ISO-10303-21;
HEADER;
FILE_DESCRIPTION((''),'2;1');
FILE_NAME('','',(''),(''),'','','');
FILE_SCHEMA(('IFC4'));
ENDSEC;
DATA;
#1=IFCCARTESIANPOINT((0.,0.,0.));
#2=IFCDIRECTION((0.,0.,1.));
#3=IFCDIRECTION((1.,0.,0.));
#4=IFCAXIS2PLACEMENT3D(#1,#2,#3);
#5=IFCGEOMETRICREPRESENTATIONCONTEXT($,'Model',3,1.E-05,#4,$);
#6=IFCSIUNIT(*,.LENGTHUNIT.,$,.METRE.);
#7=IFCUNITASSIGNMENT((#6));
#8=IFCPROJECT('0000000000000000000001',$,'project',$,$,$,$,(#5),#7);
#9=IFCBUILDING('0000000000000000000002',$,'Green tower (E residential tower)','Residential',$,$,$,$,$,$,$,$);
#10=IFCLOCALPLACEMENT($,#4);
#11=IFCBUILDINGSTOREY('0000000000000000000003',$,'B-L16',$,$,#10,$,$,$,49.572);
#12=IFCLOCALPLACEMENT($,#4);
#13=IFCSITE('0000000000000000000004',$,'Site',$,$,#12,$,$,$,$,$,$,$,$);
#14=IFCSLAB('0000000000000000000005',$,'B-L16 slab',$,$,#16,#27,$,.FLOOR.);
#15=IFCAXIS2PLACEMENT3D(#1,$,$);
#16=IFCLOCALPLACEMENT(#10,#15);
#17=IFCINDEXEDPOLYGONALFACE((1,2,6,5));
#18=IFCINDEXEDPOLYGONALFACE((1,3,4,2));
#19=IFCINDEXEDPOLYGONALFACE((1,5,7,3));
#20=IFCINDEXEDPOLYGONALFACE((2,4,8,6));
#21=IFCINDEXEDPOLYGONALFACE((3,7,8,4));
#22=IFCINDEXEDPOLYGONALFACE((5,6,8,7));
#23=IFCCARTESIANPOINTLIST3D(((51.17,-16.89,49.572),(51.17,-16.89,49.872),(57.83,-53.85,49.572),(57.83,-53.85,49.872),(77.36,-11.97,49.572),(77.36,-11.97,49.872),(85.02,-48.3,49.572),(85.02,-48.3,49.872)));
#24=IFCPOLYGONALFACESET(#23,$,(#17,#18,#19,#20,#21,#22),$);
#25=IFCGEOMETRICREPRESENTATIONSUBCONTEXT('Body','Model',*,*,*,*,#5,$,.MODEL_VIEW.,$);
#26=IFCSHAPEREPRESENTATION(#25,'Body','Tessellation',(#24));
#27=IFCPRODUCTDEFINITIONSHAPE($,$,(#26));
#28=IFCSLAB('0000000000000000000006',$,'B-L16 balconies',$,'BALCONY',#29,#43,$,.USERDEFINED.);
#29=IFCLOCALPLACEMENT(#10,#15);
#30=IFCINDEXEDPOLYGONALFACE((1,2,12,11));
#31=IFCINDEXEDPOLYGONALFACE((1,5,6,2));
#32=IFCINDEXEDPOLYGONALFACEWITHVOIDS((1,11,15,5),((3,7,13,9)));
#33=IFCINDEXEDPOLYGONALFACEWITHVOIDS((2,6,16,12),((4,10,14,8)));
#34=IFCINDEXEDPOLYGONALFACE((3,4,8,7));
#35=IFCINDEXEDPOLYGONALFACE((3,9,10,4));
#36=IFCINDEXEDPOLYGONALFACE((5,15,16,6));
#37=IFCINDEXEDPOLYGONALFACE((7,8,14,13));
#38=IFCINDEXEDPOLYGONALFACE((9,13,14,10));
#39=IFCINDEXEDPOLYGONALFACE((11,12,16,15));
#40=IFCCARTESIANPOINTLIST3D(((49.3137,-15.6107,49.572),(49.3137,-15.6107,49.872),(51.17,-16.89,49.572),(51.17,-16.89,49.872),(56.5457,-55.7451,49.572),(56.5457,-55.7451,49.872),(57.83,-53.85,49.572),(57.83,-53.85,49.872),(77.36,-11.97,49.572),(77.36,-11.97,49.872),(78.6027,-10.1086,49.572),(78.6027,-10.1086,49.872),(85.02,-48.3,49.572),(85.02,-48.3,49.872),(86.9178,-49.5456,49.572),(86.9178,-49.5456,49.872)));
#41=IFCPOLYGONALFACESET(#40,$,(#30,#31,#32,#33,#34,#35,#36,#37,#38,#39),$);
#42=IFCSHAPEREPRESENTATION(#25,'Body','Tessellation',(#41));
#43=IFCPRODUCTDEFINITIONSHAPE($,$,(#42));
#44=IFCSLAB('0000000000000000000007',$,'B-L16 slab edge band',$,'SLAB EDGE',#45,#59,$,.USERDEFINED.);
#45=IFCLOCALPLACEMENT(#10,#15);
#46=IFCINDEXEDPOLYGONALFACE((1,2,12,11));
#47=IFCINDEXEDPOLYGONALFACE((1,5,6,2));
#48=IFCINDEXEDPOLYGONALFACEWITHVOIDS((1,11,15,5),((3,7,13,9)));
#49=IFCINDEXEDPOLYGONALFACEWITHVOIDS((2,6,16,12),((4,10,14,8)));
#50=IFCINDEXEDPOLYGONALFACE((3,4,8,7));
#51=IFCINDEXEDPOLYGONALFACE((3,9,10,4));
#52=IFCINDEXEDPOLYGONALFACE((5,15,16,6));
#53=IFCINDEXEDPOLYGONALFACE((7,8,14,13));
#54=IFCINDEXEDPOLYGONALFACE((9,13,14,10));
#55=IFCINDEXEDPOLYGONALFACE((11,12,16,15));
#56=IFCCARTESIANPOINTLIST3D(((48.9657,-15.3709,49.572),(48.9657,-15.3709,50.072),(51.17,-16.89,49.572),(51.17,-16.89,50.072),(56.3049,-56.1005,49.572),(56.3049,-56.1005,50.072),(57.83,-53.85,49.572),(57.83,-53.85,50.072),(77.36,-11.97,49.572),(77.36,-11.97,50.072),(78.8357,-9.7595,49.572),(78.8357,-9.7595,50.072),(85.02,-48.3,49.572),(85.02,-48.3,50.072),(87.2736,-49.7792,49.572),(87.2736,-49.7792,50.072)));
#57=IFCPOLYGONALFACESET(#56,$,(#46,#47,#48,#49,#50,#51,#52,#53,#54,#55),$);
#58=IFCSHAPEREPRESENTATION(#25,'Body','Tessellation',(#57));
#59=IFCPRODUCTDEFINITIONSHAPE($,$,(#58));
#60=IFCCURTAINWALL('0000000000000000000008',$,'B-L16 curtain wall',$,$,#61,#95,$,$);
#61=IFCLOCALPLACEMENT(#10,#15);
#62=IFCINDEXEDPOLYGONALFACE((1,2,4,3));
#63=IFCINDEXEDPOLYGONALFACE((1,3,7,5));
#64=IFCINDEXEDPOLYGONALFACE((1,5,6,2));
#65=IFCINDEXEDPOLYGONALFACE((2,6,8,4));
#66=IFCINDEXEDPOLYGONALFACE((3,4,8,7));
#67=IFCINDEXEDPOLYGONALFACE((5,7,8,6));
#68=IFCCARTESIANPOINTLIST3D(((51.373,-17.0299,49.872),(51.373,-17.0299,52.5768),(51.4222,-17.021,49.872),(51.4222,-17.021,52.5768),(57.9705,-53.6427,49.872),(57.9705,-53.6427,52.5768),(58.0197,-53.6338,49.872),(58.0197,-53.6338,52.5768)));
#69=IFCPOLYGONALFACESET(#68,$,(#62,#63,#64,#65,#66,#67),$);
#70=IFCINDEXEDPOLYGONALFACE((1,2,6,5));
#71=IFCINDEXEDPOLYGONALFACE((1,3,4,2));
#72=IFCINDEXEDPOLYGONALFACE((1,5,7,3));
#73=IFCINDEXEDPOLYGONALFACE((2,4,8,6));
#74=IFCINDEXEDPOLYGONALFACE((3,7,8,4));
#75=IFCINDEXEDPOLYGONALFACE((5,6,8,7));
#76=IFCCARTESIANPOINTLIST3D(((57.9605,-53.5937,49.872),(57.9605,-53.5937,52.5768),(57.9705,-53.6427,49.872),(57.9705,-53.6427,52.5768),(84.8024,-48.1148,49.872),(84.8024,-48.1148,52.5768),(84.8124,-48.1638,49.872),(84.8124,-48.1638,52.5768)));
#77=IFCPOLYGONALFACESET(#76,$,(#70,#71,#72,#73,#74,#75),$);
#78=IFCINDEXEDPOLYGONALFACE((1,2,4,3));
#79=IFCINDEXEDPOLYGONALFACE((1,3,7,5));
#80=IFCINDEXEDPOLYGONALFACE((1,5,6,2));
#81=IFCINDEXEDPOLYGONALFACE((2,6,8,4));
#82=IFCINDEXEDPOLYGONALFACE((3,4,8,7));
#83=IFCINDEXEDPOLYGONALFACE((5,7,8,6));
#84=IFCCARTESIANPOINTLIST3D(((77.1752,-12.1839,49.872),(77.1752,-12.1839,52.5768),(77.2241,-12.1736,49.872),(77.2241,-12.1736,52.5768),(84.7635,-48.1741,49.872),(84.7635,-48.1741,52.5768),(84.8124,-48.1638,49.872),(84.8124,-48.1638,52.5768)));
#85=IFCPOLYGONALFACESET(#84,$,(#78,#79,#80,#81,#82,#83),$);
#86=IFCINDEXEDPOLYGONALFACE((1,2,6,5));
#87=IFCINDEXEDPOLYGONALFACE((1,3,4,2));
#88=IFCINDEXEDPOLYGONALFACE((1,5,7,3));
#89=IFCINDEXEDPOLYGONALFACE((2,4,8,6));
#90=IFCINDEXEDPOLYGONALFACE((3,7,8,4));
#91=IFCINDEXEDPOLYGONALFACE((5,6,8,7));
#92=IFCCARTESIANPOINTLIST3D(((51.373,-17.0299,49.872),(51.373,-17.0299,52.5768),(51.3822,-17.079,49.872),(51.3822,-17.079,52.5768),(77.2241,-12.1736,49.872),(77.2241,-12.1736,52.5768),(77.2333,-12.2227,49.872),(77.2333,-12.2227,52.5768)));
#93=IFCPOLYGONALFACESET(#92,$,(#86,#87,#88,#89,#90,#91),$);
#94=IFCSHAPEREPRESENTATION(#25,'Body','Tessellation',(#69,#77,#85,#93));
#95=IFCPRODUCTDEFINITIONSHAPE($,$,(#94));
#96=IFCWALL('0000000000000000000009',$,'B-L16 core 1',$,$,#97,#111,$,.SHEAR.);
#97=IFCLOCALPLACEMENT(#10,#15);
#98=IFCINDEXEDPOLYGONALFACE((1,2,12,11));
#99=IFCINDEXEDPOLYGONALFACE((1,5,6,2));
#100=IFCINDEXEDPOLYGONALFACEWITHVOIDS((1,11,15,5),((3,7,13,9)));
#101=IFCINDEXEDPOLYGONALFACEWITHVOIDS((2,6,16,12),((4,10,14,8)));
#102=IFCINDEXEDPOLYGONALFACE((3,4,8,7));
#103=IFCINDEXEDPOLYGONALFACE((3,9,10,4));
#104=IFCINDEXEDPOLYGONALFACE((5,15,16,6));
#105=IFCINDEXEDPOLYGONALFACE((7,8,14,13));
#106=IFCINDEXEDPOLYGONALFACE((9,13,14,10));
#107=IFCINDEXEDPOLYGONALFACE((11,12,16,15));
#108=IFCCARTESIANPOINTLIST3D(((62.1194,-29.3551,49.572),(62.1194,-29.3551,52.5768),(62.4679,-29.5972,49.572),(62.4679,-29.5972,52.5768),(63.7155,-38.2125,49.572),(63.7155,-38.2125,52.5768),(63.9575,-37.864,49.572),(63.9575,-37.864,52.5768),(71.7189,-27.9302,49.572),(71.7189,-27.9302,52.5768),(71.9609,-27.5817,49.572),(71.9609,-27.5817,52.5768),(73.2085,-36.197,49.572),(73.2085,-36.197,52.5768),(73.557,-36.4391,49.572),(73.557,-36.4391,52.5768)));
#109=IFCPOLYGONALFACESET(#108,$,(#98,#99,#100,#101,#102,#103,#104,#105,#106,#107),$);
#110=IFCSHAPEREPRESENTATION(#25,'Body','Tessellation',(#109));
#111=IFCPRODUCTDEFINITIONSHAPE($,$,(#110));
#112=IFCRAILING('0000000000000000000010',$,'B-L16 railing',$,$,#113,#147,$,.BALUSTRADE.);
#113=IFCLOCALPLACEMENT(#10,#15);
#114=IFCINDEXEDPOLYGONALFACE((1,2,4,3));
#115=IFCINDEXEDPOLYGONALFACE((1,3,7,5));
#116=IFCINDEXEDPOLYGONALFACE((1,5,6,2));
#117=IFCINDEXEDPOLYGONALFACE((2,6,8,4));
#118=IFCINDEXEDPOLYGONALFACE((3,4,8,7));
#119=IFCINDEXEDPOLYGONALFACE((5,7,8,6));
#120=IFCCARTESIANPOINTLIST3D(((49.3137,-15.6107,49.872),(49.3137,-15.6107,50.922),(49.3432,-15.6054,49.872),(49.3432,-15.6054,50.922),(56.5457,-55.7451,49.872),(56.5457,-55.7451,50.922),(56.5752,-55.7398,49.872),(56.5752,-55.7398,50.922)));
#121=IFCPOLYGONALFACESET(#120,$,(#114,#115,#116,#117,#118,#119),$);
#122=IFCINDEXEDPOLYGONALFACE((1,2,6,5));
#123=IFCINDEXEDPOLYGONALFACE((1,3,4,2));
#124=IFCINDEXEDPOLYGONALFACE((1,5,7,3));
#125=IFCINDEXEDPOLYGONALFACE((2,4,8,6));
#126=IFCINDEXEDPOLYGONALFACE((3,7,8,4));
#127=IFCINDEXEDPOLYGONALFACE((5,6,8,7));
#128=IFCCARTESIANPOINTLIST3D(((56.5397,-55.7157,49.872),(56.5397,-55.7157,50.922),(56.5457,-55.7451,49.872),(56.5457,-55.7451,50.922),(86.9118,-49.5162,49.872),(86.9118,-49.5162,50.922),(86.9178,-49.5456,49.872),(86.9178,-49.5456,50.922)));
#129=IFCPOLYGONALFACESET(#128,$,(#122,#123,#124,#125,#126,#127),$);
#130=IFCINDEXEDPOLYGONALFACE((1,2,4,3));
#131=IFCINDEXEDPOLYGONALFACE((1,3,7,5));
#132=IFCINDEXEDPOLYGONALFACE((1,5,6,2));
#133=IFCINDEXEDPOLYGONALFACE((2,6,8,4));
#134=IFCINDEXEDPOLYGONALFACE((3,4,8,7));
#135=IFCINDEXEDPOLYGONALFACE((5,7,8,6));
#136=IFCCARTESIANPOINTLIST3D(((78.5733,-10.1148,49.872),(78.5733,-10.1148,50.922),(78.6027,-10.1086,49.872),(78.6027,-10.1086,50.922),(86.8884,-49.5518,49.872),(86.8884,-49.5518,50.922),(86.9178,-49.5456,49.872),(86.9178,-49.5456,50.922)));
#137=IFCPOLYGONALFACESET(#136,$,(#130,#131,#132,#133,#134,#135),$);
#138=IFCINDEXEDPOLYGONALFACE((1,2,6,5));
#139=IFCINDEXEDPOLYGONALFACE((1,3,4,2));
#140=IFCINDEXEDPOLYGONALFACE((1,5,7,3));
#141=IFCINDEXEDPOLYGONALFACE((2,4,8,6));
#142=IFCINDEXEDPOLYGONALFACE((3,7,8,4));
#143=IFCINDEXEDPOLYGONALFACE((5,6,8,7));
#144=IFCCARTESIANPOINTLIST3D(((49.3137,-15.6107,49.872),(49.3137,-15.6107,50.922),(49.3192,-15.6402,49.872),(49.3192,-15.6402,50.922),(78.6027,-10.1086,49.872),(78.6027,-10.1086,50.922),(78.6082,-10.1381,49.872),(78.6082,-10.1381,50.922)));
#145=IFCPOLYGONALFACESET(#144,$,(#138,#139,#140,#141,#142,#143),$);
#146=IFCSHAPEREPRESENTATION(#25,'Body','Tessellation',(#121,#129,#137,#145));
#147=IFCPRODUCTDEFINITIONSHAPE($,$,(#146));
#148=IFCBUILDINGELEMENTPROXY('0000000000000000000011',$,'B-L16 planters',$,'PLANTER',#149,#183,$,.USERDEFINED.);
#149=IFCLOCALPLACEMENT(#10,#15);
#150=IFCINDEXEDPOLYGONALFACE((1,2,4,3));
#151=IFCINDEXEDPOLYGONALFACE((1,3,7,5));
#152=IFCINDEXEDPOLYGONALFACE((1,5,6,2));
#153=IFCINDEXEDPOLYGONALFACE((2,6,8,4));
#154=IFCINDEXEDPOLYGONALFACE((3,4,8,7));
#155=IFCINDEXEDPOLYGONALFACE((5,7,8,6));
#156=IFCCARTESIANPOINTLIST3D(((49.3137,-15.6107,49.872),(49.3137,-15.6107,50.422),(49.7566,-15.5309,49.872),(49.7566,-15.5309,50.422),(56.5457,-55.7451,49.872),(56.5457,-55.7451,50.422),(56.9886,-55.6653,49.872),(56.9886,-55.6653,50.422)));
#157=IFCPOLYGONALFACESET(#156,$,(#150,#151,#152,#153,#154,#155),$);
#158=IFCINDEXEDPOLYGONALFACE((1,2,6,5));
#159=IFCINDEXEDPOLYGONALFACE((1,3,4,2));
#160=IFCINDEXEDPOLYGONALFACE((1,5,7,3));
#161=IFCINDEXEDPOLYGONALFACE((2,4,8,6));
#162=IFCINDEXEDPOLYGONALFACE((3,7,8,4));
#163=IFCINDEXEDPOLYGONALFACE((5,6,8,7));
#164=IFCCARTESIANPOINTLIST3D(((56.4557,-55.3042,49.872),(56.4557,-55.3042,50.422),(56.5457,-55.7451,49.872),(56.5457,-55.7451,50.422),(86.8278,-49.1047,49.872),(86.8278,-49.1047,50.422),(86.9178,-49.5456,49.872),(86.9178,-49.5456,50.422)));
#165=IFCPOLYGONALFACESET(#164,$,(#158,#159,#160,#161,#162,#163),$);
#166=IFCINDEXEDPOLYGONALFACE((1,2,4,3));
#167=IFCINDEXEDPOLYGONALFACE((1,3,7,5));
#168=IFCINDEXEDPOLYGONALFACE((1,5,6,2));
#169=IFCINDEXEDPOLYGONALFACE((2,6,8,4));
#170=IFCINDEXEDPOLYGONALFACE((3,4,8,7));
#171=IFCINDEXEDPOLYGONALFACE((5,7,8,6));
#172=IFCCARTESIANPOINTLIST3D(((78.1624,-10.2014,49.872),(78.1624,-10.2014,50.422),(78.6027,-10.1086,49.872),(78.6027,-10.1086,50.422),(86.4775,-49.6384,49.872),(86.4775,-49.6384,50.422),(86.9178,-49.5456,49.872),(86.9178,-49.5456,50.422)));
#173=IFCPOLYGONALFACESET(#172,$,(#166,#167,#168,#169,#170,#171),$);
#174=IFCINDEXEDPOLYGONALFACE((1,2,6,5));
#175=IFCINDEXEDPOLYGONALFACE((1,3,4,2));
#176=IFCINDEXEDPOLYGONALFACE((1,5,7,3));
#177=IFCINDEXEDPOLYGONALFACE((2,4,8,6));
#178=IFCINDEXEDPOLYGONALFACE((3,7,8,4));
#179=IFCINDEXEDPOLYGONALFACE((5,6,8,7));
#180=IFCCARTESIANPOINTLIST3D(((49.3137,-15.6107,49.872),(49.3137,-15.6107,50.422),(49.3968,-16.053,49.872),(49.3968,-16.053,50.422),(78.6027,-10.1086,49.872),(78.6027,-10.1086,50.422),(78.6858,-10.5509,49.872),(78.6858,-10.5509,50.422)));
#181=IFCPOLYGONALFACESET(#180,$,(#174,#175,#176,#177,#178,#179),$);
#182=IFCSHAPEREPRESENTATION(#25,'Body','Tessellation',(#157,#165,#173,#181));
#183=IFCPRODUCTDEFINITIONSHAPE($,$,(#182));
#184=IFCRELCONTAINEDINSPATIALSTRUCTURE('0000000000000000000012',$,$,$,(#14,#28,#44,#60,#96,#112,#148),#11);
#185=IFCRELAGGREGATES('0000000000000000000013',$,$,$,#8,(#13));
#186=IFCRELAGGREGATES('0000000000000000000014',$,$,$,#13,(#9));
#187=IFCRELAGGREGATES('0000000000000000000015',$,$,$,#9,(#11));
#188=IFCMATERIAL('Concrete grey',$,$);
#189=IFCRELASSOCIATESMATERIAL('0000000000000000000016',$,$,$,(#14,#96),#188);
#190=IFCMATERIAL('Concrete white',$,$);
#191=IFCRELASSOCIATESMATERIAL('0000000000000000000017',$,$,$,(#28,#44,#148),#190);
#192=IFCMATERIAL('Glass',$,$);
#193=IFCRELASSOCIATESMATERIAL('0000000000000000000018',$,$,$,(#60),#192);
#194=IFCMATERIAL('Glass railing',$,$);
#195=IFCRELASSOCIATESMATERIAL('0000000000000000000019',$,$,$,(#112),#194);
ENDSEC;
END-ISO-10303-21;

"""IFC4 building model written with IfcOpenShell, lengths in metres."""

from ifc_helpers import new_model, si_unit, frame, origin_with_axes, place, context, subcontext, project, spatial, polyline, outline, extrude, material, element, save


model = new_model("IFC4")

# Units and contexts
model_context = context("Model", 3, precision=1e-05, world=origin_with_axes())
body_context = subcontext(model_context, "Body", "Model", "MODEL_VIEW")
ifc_project = project(units=[si_unit("LENGTHUNIT", "METRE")], contexts=[model_context])

# Site, building, storey
site_placement = place(None, origin_with_axes())
site = spatial("IfcSite", under=ifc_project, at=site_placement, Name="Site")
building = spatial("IfcBuilding", under=site, Name="Green tower (E residential tower)", Description="Residential")
storey_placement = place(None, origin_with_axes())
storey = spatial("IfcBuildingStorey", under=building, at=storey_placement, Name="B-L16", Elevation=49.572)

# Slabs
ifc_material_1 = material(Name="Concrete grey")
slab_1_placement = place(storey_placement, origin_with_axes())
element("IfcSlab", 1, at=slab_1_placement, inside=storey, material=ifc_material_1, Name="B-L16 slab", PredefinedType="FLOOR", context=body_context, shape_type="SweptSolid", body=[
    extrude(outline(polyline([(51.17, -16.89), (57.83, -53.85), (85.02, -48.3), (77.36, -11.97), (51.17, -16.89)])), frame((0.0, 0.0, 49.572), z_axis=(0.0, 0.0, 1.0), x_axis=(1.0, 0.0, 0.0)), (0.0, 0.0, 1.0), 0.3),
])
ifc_material_2 = material(Name="Concrete white")
slab_2_placement = place(storey_placement, origin_with_axes())
element("IfcSlab", 2, at=slab_2_placement, inside=storey, material=ifc_material_2, Name="B-L16 balconies", ObjectType="BALCONY", PredefinedType="USERDEFINED", context=body_context, shape_type="SweptSolid", body=[
    extrude(outline(polyline([(49.3137, -15.6107), (56.5457, -55.7451), (86.9178, -49.5456), (78.6027, -10.1086), (49.3137, -15.6107)]), holes=[polyline([(51.17, -16.89), (57.83, -53.85), (85.02, -48.3), (77.36, -11.97), (51.17, -16.89)])]), frame((0.0, 0.0, 49.572), z_axis=(0.0, 0.0, 1.0), x_axis=(1.0, 0.0, 0.0)), (0.0, 0.0, 1.0), 0.3),
])
slab_3_placement = place(storey_placement, origin_with_axes())
element("IfcSlab", 3, at=slab_3_placement, inside=storey, material=ifc_material_2, Name="B-L16 slab edge band", ObjectType="SLAB EDGE", PredefinedType="USERDEFINED", context=body_context, shape_type="SweptSolid", body=[
    extrude(outline(polyline([(48.9657, -15.3709), (56.3049, -56.1005), (87.2736, -49.7792), (78.8357, -9.7595), (48.9657, -15.3709)]), holes=[polyline([(51.17, -16.89), (57.83, -53.85), (85.02, -48.3), (77.36, -11.97), (51.17, -16.89)])]), frame((0.0, 0.0, 49.572), z_axis=(0.0, 0.0, 1.0), x_axis=(1.0, 0.0, 0.0)), (0.0, 0.0, 1.0), 0.5),
])

# Curtain wall
ifc_material_3 = material(Name="Glass")
curtain_wall_placement = place(storey_placement, origin_with_axes())
element("IfcCurtainWall", 4, at=curtain_wall_placement, inside=storey, material=ifc_material_3, Name="B-L16 curtain wall", context=body_context, shape_type="SweptSolid", body=[
    extrude(outline(polyline([(51.373, -17.0299), (57.9705, -53.6427), (58.0197, -53.6338), (51.4222, -17.021), (51.373, -17.0299)])), frame((0.0, 0.0, 49.872), z_axis=(0.0, 0.0, 1.0), x_axis=(1.0, 0.0, 0.0)), (0.0, 0.0, 1.0), 2.7048),
    extrude(outline(polyline([(57.9705, -53.6427), (84.8124, -48.1638), (84.8024, -48.1148), (57.9605, -53.5937), (57.9705, -53.6427)])), frame((0.0, 0.0, 49.872), z_axis=(0.0, 0.0, 1.0), x_axis=(1.0, 0.0, 0.0)), (0.0, 0.0, 1.0), 2.7048),
    extrude(outline(polyline([(84.8124, -48.1638), (77.2241, -12.1736), (77.1752, -12.1839), (84.7635, -48.1741), (84.8124, -48.1638)])), frame((0.0, 0.0, 49.872), z_axis=(0.0, 0.0, 1.0), x_axis=(1.0, 0.0, 0.0)), (0.0, 0.0, 1.0), 2.7048),
    extrude(outline(polyline([(77.2241, -12.1736), (51.373, -17.0299), (51.3822, -17.079), (77.2333, -12.2227), (77.2241, -12.1736)])), frame((0.0, 0.0, 49.872), z_axis=(0.0, 0.0, 1.0), x_axis=(1.0, 0.0, 0.0)), (0.0, 0.0, 1.0), 2.7048),
])

# Wall
wall_placement = place(storey_placement, origin_with_axes())
element("IfcWall", 5, at=wall_placement, inside=storey, material=ifc_material_1, Name="B-L16 core 1", PredefinedType="SHEAR", context=body_context, shape_type="SweptSolid", body=[
    extrude(outline(polyline([(62.1194, -29.3551), (63.7155, -38.2125), (73.557, -36.4391), (71.9609, -27.5817), (62.1194, -29.3551)]), holes=[polyline([(62.4679, -29.5972), (63.9575, -37.864), (73.2085, -36.197), (71.7189, -27.9302), (62.4679, -29.5972)])]), frame((0.0, 0.0, 49.572), z_axis=(0.0, 0.0, 1.0), x_axis=(1.0, 0.0, 0.0)), (0.0, 0.0, 1.0), 3.0048),
])

# Railing
ifc_material_4 = material(Name="Glass railing")
railing_placement = place(storey_placement, origin_with_axes())
element("IfcRailing", 6, at=railing_placement, inside=storey, material=ifc_material_4, Name="B-L16 railing", PredefinedType="BALUSTRADE", context=body_context, shape_type="SweptSolid", body=[
    extrude(outline(polyline([(49.3137, -15.6107), (56.5457, -55.7451), (56.5752, -55.7398), (49.3432, -15.6054), (49.3137, -15.6107)])), frame((0.0, 0.0, 49.872), z_axis=(0.0, 0.0, 1.0), x_axis=(1.0, 0.0, 0.0)), (0.0, 0.0, 1.0), 1.05),
    extrude(outline(polyline([(56.5457, -55.7451), (86.9178, -49.5456), (86.9118, -49.5162), (56.5397, -55.7157), (56.5457, -55.7451)])), frame((0.0, 0.0, 49.872), z_axis=(0.0, 0.0, 1.0), x_axis=(1.0, 0.0, 0.0)), (0.0, 0.0, 1.0), 1.05),
    extrude(outline(polyline([(86.9178, -49.5456), (78.6027, -10.1086), (78.5733, -10.1148), (86.8884, -49.5518), (86.9178, -49.5456)])), frame((0.0, 0.0, 49.872), z_axis=(0.0, 0.0, 1.0), x_axis=(1.0, 0.0, 0.0)), (0.0, 0.0, 1.0), 1.05),
    extrude(outline(polyline([(78.6027, -10.1086), (49.3137, -15.6107), (49.3192, -15.6402), (78.6082, -10.1381), (78.6027, -10.1086)])), frame((0.0, 0.0, 49.872), z_axis=(0.0, 0.0, 1.0), x_axis=(1.0, 0.0, 0.0)), (0.0, 0.0, 1.0), 1.05),
])

# Building element proxy
proxy_1_placement = place(storey_placement, origin_with_axes())
element("IfcBuildingElementProxy", 7, at=proxy_1_placement, inside=storey, material=ifc_material_2, Name="B-L16 planters", ObjectType="PLANTER", PredefinedType="USERDEFINED", context=body_context, shape_type="SweptSolid", body=[
    extrude(outline(polyline([(49.3137, -15.6107), (56.5457, -55.7451), (56.9886, -55.6653), (49.7566, -15.5309), (49.3137, -15.6107)])), frame((0.0, 0.0, 49.872), z_axis=(0.0, 0.0, 1.0), x_axis=(1.0, 0.0, 0.0)), (0.0, 0.0, 1.0), 0.55),
    extrude(outline(polyline([(56.5457, -55.7451), (86.9178, -49.5456), (86.8278, -49.1047), (56.4557, -55.3042), (56.5457, -55.7451)])), frame((0.0, 0.0, 49.872), z_axis=(0.0, 0.0, 1.0), x_axis=(1.0, 0.0, 0.0)), (0.0, 0.0, 1.0), 0.55),
    extrude(outline(polyline([(86.9178, -49.5456), (78.6027, -10.1086), (78.1624, -10.2014), (86.4775, -49.6384), (86.9178, -49.5456)])), frame((0.0, 0.0, 49.872), z_axis=(0.0, 0.0, 1.0), x_axis=(1.0, 0.0, 0.0)), (0.0, 0.0, 1.0), 0.55),
    extrude(outline(polyline([(78.6027, -10.1086), (49.3137, -15.6107), (49.3968, -16.053), (78.6858, -10.5509), (78.6027, -10.1086)])), frame((0.0, 0.0, 49.872), z_axis=(0.0, 0.0, 1.0), x_axis=(1.0, 0.0, 0.0)), (0.0, 0.0, 1.0), 0.55),
])

save(model, "model.ifc")
